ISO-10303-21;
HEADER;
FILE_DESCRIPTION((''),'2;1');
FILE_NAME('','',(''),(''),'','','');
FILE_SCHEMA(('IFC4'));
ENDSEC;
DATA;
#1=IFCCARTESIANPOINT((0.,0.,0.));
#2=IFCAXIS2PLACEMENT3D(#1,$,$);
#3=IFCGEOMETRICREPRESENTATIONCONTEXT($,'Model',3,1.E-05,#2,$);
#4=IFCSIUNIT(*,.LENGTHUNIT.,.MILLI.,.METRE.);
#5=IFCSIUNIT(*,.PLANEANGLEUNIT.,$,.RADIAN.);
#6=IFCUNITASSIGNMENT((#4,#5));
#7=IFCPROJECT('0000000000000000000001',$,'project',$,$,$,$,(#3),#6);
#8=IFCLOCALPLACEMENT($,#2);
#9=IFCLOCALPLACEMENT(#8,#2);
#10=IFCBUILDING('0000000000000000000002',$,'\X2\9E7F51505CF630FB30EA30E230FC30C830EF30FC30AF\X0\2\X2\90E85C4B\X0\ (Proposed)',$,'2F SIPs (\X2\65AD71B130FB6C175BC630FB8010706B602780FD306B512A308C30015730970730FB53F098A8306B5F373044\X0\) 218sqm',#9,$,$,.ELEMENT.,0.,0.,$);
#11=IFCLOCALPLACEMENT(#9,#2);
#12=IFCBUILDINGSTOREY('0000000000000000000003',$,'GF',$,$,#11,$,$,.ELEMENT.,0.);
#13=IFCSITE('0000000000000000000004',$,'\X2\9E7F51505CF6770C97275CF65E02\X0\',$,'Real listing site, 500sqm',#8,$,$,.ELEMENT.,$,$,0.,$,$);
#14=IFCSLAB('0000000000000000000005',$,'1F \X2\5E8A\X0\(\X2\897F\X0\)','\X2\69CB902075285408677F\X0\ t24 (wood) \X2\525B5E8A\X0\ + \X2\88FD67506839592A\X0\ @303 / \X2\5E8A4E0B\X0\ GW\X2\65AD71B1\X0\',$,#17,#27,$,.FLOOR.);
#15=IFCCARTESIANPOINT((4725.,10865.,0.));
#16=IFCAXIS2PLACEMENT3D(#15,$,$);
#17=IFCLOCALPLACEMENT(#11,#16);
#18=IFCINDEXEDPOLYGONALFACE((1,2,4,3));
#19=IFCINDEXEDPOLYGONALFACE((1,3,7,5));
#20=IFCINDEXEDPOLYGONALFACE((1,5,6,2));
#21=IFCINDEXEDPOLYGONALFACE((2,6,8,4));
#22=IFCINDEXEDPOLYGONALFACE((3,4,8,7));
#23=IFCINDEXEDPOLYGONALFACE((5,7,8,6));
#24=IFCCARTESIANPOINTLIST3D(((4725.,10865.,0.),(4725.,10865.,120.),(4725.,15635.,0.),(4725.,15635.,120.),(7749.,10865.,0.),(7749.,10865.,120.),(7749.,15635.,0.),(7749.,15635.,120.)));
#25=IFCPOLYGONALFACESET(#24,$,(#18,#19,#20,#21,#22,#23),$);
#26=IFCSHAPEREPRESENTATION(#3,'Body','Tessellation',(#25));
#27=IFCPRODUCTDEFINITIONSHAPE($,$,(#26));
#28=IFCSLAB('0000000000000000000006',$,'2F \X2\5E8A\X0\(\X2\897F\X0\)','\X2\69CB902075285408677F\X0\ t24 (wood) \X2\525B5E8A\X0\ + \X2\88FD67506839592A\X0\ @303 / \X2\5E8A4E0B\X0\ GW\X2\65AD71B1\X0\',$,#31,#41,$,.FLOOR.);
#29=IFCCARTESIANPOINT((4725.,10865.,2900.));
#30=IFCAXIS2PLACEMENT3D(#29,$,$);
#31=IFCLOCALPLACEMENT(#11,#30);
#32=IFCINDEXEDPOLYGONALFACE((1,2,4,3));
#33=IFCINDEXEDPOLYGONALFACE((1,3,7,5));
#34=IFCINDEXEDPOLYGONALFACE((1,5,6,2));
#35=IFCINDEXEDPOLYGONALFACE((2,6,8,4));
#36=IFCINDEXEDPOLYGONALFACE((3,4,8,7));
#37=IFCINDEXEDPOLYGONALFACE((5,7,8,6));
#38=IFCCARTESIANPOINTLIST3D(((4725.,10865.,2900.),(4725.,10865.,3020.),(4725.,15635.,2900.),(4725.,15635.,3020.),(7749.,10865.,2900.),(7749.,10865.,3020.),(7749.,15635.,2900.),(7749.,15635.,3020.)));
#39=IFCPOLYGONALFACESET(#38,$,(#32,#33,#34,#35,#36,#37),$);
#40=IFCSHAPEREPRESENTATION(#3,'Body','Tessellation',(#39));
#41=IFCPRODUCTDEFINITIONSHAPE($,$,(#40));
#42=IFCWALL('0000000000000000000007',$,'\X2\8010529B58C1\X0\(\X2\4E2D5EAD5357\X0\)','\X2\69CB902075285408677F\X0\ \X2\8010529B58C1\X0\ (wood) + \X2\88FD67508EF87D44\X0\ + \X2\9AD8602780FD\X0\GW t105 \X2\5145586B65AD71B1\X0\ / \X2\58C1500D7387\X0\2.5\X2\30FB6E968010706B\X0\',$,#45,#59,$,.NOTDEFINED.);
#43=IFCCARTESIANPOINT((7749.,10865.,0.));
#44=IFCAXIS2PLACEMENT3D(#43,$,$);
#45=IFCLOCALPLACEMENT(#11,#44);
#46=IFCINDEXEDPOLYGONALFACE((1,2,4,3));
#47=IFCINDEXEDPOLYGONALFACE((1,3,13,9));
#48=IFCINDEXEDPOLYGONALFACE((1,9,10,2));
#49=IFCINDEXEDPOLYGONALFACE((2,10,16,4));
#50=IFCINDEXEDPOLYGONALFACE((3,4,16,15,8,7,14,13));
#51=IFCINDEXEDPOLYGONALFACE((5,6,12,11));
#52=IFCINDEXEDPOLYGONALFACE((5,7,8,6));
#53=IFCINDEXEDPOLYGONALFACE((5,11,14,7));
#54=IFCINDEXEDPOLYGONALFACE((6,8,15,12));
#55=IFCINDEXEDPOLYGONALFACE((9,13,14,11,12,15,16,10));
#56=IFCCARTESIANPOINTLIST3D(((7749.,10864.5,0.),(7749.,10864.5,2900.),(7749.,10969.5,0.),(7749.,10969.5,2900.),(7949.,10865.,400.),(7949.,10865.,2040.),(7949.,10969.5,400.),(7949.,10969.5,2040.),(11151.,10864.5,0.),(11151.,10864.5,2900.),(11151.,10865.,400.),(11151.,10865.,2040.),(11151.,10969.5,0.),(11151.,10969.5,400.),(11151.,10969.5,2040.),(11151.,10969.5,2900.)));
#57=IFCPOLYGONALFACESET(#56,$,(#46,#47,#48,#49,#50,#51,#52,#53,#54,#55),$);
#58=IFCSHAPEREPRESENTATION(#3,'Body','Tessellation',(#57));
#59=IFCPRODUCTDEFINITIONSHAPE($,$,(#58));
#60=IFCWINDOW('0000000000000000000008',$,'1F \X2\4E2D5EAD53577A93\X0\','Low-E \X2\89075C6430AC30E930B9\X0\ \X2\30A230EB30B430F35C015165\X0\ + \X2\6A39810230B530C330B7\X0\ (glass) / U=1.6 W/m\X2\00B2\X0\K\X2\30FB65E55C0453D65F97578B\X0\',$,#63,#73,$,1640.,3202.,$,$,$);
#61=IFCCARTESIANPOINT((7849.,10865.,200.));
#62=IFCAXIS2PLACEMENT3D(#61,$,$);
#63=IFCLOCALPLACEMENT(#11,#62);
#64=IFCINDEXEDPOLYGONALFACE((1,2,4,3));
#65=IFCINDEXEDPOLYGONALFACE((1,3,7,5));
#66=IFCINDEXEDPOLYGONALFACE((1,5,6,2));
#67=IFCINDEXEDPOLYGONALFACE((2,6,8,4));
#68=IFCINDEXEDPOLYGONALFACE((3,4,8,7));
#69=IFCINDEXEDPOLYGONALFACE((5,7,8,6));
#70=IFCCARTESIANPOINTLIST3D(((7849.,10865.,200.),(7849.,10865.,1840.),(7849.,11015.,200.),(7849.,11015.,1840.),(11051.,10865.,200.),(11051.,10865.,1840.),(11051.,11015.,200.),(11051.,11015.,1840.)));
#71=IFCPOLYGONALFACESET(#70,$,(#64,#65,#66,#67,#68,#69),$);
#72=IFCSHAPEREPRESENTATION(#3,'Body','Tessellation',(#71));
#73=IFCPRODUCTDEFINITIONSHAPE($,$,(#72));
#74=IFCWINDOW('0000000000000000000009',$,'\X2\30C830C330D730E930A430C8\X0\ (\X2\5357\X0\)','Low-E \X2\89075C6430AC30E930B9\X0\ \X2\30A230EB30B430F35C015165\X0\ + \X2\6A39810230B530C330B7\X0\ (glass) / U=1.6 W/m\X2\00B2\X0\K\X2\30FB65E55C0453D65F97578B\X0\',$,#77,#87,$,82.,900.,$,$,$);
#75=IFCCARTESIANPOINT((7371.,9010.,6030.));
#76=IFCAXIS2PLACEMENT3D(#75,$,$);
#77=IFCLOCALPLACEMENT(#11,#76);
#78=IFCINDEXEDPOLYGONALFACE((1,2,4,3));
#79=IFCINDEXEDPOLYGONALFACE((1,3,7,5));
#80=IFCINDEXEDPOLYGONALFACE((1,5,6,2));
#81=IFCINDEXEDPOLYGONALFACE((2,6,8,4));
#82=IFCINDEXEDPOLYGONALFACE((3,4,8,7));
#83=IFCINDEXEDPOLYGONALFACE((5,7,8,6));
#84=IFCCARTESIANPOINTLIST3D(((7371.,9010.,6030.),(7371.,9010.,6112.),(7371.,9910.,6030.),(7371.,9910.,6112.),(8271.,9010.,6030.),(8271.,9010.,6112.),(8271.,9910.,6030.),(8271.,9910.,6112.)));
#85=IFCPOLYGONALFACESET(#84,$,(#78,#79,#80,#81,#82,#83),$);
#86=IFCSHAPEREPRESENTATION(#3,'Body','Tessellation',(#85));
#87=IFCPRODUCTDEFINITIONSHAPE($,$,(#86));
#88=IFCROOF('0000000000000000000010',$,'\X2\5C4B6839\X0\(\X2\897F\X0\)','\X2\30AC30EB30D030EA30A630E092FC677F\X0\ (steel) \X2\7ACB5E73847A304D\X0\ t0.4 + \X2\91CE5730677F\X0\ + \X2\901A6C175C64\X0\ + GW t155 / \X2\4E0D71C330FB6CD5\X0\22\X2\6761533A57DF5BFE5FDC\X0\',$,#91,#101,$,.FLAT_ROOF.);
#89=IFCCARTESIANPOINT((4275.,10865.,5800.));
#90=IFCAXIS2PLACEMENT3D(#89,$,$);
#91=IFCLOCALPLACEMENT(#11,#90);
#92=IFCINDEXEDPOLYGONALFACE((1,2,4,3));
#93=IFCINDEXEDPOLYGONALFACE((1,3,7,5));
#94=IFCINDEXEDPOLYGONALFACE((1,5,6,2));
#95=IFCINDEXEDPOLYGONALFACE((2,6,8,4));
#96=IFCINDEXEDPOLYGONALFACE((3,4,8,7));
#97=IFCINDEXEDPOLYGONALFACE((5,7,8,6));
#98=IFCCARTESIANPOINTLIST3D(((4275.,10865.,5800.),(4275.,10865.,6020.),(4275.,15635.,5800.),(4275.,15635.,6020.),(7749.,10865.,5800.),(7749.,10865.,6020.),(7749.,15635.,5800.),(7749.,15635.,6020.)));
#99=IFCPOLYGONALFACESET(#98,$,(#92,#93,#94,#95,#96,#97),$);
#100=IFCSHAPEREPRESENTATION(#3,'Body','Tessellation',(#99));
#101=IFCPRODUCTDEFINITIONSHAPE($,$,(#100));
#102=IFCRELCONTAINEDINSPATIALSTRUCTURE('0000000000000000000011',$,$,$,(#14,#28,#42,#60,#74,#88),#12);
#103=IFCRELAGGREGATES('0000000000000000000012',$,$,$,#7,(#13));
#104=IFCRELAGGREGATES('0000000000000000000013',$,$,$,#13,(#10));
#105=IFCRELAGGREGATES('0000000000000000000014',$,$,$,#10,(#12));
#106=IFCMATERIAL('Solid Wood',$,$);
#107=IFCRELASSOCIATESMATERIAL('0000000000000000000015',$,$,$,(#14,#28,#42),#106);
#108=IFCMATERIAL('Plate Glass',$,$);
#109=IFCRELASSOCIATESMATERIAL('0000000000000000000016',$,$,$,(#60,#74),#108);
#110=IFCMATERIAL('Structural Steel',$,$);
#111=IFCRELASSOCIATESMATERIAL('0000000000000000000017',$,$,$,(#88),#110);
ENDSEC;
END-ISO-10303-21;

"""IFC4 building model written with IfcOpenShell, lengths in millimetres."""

from ifc_helpers import new_model, si_unit, frame, frame_2d, origin, place, context, project, spatial, rectangle, extrude, material, element, fill, save


model = new_model("IFC4")

# Units and contexts
model_context = context("Model", 3, precision=1e-05, world=origin())
ifc_project = project(units=[si_unit("LENGTHUNIT", "METRE", prefix="MILLI"), si_unit("PLANEANGLEUNIT", "RADIAN")], contexts=[model_context])

# Site, building, storey
site_placement = place(None, origin())
site = spatial("IfcSite", under=ifc_project, at=site_placement, Name="鹿児島県霧島市", ObjectType="Real listing site, 500sqm", CompositionType="ELEMENT", RefElevation=0.0)
building_placement = place(site_placement, origin())
building = spatial("IfcBuilding", under=site, at=building_placement, Name="鹿児島・リモートワーク2部屋 (Proposed)", ObjectType="2F SIPs (断熱・気密・耐火性能に優れ、地震・台風に強い) 218sqm", CompositionType="ELEMENT", ElevationOfRefHeight=0.0, ElevationOfTerrain=0.0)
storey_placement = place(building_placement, origin())
storey = spatial("IfcBuildingStorey", under=building, at=storey_placement, Name="GF", CompositionType="ELEMENT", Elevation=0.0)

# Shared definitions
ifc_material_1 = material(Name="Solid Wood")

# Slabs
slab_1_placement = place(storey_placement, frame((4725.0, 10865.0, 0.0)))
element("IfcSlab", 1, at=slab_1_placement, inside=storey, material=ifc_material_1, Name="1F 床(西)", Description="構造用合板 t24 (wood) 剛床 + 製材根太 @303 / 床下 GW断熱", PredefinedType="FLOOR", context=model_context, shape_type="SweptSolid", body=[
    extrude(rectangle(XDim=3024.0, YDim=4770.0, at=frame_2d((1512.0, 2385.0))), frame((4725.0, 10865.0, 0.0)), (0.0, 0.0, 1.0), 120.0),
])
slab_2_placement = place(storey_placement, frame((4725.0, 10865.0, 2900.0)))
element("IfcSlab", 2, at=slab_2_placement, inside=storey, material=ifc_material_1, Name="2F 床(西)", Description="構造用合板 t24 (wood) 剛床 + 製材根太 @303 / 床下 GW断熱", PredefinedType="FLOOR", context=model_context, shape_type="SweptSolid", body=[
    extrude(rectangle(XDim=3024.0, YDim=4770.0, at=frame_2d((1512.0, 2385.0))), frame((4725.0, 10865.0, 2900.0)), (0.0, 0.0, 1.0), 120.0),
])

# Wall, opening, window
wall_placement = place(storey_placement, frame((7749.0, 10865.0, 0.0)))
wall = element("IfcWall", 3, at=wall_placement, inside=storey, material=ifc_material_1, Name="耐力壁(中庭南)", Description="構造用合板 耐力壁 (wood) + 製材軸組 + 高性能GW t105 充填断熱 / 壁倍率2.5・準耐火", PredefinedType="NOTDEFINED", context=model_context, shape_type="SweptSolid", body=[
    extrude(rectangle(XDim=3402.0, YDim=105.0, at=frame_2d((1701.0, 52.0))), frame((7749.0, 10865.0, 0.0)), (0.0, 0.0, 1.0), 2900.0),
])
opening_placement = place(storey_placement, frame((7849.0, 10865.0, 200.0)))
opening = element("IfcOpeningElement", 4, at=opening_placement, cuts=wall, PredefinedType="NOTDEFINED", context=model_context, shape_type="SweptSolid", body=[
    extrude(rectangle(XDim=3202.0, YDim=150.0, at=frame_2d((1601.0, 75.0))), frame((7849.0, 10865.0, 200.0)), (0.0, 0.0, 1.0), 1640.0),
])
ifc_material_2 = material(Name="Plate Glass")
window_1_placement = place(storey_placement, frame((7849.0, 10865.0, 200.0)))
window_1 = element("IfcWindow", 5, at=window_1_placement, inside=storey, material=ifc_material_2, Name="1F 中庭南窓", Description="Low-E 複層ガラス アルゴン封入 + 樹脂サッシ (glass) / U=1.6 W/m²K・日射取得型", OverallHeight=1640.0, OverallWidth=3202.0, context=model_context, shape_type="SweptSolid", body=[
    extrude(rectangle(XDim=3202.0, YDim=150.0, at=frame_2d((1601.0, 75.0))), frame((7849.0, 10865.0, 200.0)), (0.0, 0.0, 1.0), 1640.0),
])
fill(opening, window_1)

# Window
window_2_placement = place(storey_placement, frame((7371.0, 9010.0, 6030.0)))
element("IfcWindow", 6, at=window_2_placement, inside=storey, material=ifc_material_2, Name="トップライト (南)", Description="Low-E 複層ガラス アルゴン封入 + 樹脂サッシ (glass) / U=1.6 W/m²K・日射取得型", OverallHeight=82.0, OverallWidth=900.0, context=model_context, shape_type="SweptSolid", body=[
    extrude(rectangle(XDim=900.0, YDim=900.0, at=frame_2d((450.0, 450.0))), frame((7371.0, 9010.0, 6030.0)), (0.0, 0.0, 1.0), 82.0),
])

# Roof
ifc_material_3 = material(Name="Structural Steel")
for number, where, name in (
    (7, (4275.0, 10865.0, 5800.0), "屋根(西)"),
):
    element("IfcRoof", number, at=place(storey_placement, frame(where)), inside=storey, material=ifc_material_3, Name=name, Description="ガルバリウム鋼板 (steel) 立平葺き t0.4 + 野地板 + 通気層 + GW t155 / 不燃・法22条区域対応", PredefinedType="FLAT_ROOF", context=model_context, shape_type="SweptSolid", body=[
        extrude(rectangle(XDim=3474.0, YDim=4770.0, at=frame_2d((1737.0, 2385.0))), frame((4275.0, 10865.0, 5800.0)), (0.0, 0.0, 1.0), 220.0),
    ])

save(model, "model.ifc")
